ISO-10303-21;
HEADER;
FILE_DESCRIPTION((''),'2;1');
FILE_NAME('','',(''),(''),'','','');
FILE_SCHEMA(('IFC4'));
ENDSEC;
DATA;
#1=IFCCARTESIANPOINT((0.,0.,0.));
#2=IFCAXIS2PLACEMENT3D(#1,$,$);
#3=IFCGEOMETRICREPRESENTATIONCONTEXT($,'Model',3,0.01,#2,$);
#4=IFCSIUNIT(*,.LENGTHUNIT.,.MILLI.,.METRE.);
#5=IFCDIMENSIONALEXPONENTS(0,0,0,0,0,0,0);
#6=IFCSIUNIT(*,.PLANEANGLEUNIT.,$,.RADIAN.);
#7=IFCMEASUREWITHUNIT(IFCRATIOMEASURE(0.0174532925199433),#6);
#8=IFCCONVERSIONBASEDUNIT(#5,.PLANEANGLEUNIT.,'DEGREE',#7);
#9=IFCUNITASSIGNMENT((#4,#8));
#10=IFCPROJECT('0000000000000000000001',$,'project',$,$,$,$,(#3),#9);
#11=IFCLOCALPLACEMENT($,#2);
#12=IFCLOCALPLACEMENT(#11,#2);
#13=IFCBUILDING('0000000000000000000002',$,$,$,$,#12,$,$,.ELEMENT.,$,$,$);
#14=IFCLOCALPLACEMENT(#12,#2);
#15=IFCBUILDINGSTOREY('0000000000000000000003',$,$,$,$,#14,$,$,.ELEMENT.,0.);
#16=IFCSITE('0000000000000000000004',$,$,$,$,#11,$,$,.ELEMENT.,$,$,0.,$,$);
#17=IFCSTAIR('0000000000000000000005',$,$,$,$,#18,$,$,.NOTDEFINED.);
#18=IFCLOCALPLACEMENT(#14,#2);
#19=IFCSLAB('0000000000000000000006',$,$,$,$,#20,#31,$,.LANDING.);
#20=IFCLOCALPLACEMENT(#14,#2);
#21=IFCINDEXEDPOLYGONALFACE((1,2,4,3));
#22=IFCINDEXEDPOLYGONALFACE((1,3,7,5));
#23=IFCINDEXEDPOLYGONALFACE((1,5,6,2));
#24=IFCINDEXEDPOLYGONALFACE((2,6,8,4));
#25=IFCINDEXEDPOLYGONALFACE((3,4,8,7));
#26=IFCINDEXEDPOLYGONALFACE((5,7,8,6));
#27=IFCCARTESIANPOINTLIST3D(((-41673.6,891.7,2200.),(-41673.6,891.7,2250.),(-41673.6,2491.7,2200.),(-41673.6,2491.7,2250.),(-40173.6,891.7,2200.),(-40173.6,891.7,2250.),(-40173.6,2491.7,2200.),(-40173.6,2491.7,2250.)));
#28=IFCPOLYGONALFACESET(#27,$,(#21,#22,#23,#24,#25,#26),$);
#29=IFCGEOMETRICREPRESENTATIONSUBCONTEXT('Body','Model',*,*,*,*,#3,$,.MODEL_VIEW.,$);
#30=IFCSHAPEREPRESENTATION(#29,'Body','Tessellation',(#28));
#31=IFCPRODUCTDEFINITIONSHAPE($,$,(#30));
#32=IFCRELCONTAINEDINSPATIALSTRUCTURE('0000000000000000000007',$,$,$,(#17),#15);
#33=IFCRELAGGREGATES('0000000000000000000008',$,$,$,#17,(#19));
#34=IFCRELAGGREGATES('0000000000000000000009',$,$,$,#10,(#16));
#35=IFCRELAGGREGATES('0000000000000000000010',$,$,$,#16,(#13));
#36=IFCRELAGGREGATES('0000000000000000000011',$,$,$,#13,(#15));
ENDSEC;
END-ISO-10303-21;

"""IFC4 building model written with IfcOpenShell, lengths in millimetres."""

from ifc_helpers import new_model, entity, si_unit, converted_unit, frame, frame_2d, origin, place, context, subcontext, project, spatial, rectangle, extrude, element, aggregate, save


model = new_model("IFC4")

# Units and contexts
model_context = context("Model", 3, precision=0.01, world=origin())
body_context = subcontext(model_context, "Body", "Model", "MODEL_VIEW")
ifc_project = project(units=[si_unit("LENGTHUNIT", "METRE", prefix="MILLI"), converted_unit("PLANEANGLEUNIT", "DEGREE", entity("IfcRatioMeasure", 0.0174532925199433), si_unit("PLANEANGLEUNIT", "RADIAN"), dimensions=[0, 0, 0, 0, 0, 0, 0])], contexts=[model_context])

# Site, building, storey
site_placement = place(None, origin())
site = spatial("IfcSite", under=ifc_project, at=site_placement, CompositionType="ELEMENT", RefElevation=0.0)
building_placement = place(site_placement, origin())
building = spatial("IfcBuilding", under=site, at=building_placement, CompositionType="ELEMENT")
storey_placement = place(building_placement, origin())
storey = spatial("IfcBuildingStorey", under=building, at=storey_placement, CompositionType="ELEMENT", Elevation=0.0)

# Stair, slab
stair_placement = place(storey_placement, origin())
stair = element("IfcStair", 1, at=stair_placement, inside=storey, PredefinedType="NOTDEFINED")
slab_placement = place(stair_placement, origin())
slab = element("IfcSlab", 2, at=slab_placement, PredefinedType="LANDING", context=body_context, shape_type="SweptSolid", body=[
    extrude(rectangle(XDim=1500.0, YDim=1600.0, at=frame_2d((0.0, 0.0), x_axis=(1.0, 0.0))), frame((-40923.6, 1691.7, 2200.0), z_axis=(0.0, 0.0, 1.0), x_axis=(-1.0, 0.0, 0.0)), (0.0, 0.0, 1.0), 50.0),
])
aggregate(stair, [slab])

save(model, "model.ifc")
